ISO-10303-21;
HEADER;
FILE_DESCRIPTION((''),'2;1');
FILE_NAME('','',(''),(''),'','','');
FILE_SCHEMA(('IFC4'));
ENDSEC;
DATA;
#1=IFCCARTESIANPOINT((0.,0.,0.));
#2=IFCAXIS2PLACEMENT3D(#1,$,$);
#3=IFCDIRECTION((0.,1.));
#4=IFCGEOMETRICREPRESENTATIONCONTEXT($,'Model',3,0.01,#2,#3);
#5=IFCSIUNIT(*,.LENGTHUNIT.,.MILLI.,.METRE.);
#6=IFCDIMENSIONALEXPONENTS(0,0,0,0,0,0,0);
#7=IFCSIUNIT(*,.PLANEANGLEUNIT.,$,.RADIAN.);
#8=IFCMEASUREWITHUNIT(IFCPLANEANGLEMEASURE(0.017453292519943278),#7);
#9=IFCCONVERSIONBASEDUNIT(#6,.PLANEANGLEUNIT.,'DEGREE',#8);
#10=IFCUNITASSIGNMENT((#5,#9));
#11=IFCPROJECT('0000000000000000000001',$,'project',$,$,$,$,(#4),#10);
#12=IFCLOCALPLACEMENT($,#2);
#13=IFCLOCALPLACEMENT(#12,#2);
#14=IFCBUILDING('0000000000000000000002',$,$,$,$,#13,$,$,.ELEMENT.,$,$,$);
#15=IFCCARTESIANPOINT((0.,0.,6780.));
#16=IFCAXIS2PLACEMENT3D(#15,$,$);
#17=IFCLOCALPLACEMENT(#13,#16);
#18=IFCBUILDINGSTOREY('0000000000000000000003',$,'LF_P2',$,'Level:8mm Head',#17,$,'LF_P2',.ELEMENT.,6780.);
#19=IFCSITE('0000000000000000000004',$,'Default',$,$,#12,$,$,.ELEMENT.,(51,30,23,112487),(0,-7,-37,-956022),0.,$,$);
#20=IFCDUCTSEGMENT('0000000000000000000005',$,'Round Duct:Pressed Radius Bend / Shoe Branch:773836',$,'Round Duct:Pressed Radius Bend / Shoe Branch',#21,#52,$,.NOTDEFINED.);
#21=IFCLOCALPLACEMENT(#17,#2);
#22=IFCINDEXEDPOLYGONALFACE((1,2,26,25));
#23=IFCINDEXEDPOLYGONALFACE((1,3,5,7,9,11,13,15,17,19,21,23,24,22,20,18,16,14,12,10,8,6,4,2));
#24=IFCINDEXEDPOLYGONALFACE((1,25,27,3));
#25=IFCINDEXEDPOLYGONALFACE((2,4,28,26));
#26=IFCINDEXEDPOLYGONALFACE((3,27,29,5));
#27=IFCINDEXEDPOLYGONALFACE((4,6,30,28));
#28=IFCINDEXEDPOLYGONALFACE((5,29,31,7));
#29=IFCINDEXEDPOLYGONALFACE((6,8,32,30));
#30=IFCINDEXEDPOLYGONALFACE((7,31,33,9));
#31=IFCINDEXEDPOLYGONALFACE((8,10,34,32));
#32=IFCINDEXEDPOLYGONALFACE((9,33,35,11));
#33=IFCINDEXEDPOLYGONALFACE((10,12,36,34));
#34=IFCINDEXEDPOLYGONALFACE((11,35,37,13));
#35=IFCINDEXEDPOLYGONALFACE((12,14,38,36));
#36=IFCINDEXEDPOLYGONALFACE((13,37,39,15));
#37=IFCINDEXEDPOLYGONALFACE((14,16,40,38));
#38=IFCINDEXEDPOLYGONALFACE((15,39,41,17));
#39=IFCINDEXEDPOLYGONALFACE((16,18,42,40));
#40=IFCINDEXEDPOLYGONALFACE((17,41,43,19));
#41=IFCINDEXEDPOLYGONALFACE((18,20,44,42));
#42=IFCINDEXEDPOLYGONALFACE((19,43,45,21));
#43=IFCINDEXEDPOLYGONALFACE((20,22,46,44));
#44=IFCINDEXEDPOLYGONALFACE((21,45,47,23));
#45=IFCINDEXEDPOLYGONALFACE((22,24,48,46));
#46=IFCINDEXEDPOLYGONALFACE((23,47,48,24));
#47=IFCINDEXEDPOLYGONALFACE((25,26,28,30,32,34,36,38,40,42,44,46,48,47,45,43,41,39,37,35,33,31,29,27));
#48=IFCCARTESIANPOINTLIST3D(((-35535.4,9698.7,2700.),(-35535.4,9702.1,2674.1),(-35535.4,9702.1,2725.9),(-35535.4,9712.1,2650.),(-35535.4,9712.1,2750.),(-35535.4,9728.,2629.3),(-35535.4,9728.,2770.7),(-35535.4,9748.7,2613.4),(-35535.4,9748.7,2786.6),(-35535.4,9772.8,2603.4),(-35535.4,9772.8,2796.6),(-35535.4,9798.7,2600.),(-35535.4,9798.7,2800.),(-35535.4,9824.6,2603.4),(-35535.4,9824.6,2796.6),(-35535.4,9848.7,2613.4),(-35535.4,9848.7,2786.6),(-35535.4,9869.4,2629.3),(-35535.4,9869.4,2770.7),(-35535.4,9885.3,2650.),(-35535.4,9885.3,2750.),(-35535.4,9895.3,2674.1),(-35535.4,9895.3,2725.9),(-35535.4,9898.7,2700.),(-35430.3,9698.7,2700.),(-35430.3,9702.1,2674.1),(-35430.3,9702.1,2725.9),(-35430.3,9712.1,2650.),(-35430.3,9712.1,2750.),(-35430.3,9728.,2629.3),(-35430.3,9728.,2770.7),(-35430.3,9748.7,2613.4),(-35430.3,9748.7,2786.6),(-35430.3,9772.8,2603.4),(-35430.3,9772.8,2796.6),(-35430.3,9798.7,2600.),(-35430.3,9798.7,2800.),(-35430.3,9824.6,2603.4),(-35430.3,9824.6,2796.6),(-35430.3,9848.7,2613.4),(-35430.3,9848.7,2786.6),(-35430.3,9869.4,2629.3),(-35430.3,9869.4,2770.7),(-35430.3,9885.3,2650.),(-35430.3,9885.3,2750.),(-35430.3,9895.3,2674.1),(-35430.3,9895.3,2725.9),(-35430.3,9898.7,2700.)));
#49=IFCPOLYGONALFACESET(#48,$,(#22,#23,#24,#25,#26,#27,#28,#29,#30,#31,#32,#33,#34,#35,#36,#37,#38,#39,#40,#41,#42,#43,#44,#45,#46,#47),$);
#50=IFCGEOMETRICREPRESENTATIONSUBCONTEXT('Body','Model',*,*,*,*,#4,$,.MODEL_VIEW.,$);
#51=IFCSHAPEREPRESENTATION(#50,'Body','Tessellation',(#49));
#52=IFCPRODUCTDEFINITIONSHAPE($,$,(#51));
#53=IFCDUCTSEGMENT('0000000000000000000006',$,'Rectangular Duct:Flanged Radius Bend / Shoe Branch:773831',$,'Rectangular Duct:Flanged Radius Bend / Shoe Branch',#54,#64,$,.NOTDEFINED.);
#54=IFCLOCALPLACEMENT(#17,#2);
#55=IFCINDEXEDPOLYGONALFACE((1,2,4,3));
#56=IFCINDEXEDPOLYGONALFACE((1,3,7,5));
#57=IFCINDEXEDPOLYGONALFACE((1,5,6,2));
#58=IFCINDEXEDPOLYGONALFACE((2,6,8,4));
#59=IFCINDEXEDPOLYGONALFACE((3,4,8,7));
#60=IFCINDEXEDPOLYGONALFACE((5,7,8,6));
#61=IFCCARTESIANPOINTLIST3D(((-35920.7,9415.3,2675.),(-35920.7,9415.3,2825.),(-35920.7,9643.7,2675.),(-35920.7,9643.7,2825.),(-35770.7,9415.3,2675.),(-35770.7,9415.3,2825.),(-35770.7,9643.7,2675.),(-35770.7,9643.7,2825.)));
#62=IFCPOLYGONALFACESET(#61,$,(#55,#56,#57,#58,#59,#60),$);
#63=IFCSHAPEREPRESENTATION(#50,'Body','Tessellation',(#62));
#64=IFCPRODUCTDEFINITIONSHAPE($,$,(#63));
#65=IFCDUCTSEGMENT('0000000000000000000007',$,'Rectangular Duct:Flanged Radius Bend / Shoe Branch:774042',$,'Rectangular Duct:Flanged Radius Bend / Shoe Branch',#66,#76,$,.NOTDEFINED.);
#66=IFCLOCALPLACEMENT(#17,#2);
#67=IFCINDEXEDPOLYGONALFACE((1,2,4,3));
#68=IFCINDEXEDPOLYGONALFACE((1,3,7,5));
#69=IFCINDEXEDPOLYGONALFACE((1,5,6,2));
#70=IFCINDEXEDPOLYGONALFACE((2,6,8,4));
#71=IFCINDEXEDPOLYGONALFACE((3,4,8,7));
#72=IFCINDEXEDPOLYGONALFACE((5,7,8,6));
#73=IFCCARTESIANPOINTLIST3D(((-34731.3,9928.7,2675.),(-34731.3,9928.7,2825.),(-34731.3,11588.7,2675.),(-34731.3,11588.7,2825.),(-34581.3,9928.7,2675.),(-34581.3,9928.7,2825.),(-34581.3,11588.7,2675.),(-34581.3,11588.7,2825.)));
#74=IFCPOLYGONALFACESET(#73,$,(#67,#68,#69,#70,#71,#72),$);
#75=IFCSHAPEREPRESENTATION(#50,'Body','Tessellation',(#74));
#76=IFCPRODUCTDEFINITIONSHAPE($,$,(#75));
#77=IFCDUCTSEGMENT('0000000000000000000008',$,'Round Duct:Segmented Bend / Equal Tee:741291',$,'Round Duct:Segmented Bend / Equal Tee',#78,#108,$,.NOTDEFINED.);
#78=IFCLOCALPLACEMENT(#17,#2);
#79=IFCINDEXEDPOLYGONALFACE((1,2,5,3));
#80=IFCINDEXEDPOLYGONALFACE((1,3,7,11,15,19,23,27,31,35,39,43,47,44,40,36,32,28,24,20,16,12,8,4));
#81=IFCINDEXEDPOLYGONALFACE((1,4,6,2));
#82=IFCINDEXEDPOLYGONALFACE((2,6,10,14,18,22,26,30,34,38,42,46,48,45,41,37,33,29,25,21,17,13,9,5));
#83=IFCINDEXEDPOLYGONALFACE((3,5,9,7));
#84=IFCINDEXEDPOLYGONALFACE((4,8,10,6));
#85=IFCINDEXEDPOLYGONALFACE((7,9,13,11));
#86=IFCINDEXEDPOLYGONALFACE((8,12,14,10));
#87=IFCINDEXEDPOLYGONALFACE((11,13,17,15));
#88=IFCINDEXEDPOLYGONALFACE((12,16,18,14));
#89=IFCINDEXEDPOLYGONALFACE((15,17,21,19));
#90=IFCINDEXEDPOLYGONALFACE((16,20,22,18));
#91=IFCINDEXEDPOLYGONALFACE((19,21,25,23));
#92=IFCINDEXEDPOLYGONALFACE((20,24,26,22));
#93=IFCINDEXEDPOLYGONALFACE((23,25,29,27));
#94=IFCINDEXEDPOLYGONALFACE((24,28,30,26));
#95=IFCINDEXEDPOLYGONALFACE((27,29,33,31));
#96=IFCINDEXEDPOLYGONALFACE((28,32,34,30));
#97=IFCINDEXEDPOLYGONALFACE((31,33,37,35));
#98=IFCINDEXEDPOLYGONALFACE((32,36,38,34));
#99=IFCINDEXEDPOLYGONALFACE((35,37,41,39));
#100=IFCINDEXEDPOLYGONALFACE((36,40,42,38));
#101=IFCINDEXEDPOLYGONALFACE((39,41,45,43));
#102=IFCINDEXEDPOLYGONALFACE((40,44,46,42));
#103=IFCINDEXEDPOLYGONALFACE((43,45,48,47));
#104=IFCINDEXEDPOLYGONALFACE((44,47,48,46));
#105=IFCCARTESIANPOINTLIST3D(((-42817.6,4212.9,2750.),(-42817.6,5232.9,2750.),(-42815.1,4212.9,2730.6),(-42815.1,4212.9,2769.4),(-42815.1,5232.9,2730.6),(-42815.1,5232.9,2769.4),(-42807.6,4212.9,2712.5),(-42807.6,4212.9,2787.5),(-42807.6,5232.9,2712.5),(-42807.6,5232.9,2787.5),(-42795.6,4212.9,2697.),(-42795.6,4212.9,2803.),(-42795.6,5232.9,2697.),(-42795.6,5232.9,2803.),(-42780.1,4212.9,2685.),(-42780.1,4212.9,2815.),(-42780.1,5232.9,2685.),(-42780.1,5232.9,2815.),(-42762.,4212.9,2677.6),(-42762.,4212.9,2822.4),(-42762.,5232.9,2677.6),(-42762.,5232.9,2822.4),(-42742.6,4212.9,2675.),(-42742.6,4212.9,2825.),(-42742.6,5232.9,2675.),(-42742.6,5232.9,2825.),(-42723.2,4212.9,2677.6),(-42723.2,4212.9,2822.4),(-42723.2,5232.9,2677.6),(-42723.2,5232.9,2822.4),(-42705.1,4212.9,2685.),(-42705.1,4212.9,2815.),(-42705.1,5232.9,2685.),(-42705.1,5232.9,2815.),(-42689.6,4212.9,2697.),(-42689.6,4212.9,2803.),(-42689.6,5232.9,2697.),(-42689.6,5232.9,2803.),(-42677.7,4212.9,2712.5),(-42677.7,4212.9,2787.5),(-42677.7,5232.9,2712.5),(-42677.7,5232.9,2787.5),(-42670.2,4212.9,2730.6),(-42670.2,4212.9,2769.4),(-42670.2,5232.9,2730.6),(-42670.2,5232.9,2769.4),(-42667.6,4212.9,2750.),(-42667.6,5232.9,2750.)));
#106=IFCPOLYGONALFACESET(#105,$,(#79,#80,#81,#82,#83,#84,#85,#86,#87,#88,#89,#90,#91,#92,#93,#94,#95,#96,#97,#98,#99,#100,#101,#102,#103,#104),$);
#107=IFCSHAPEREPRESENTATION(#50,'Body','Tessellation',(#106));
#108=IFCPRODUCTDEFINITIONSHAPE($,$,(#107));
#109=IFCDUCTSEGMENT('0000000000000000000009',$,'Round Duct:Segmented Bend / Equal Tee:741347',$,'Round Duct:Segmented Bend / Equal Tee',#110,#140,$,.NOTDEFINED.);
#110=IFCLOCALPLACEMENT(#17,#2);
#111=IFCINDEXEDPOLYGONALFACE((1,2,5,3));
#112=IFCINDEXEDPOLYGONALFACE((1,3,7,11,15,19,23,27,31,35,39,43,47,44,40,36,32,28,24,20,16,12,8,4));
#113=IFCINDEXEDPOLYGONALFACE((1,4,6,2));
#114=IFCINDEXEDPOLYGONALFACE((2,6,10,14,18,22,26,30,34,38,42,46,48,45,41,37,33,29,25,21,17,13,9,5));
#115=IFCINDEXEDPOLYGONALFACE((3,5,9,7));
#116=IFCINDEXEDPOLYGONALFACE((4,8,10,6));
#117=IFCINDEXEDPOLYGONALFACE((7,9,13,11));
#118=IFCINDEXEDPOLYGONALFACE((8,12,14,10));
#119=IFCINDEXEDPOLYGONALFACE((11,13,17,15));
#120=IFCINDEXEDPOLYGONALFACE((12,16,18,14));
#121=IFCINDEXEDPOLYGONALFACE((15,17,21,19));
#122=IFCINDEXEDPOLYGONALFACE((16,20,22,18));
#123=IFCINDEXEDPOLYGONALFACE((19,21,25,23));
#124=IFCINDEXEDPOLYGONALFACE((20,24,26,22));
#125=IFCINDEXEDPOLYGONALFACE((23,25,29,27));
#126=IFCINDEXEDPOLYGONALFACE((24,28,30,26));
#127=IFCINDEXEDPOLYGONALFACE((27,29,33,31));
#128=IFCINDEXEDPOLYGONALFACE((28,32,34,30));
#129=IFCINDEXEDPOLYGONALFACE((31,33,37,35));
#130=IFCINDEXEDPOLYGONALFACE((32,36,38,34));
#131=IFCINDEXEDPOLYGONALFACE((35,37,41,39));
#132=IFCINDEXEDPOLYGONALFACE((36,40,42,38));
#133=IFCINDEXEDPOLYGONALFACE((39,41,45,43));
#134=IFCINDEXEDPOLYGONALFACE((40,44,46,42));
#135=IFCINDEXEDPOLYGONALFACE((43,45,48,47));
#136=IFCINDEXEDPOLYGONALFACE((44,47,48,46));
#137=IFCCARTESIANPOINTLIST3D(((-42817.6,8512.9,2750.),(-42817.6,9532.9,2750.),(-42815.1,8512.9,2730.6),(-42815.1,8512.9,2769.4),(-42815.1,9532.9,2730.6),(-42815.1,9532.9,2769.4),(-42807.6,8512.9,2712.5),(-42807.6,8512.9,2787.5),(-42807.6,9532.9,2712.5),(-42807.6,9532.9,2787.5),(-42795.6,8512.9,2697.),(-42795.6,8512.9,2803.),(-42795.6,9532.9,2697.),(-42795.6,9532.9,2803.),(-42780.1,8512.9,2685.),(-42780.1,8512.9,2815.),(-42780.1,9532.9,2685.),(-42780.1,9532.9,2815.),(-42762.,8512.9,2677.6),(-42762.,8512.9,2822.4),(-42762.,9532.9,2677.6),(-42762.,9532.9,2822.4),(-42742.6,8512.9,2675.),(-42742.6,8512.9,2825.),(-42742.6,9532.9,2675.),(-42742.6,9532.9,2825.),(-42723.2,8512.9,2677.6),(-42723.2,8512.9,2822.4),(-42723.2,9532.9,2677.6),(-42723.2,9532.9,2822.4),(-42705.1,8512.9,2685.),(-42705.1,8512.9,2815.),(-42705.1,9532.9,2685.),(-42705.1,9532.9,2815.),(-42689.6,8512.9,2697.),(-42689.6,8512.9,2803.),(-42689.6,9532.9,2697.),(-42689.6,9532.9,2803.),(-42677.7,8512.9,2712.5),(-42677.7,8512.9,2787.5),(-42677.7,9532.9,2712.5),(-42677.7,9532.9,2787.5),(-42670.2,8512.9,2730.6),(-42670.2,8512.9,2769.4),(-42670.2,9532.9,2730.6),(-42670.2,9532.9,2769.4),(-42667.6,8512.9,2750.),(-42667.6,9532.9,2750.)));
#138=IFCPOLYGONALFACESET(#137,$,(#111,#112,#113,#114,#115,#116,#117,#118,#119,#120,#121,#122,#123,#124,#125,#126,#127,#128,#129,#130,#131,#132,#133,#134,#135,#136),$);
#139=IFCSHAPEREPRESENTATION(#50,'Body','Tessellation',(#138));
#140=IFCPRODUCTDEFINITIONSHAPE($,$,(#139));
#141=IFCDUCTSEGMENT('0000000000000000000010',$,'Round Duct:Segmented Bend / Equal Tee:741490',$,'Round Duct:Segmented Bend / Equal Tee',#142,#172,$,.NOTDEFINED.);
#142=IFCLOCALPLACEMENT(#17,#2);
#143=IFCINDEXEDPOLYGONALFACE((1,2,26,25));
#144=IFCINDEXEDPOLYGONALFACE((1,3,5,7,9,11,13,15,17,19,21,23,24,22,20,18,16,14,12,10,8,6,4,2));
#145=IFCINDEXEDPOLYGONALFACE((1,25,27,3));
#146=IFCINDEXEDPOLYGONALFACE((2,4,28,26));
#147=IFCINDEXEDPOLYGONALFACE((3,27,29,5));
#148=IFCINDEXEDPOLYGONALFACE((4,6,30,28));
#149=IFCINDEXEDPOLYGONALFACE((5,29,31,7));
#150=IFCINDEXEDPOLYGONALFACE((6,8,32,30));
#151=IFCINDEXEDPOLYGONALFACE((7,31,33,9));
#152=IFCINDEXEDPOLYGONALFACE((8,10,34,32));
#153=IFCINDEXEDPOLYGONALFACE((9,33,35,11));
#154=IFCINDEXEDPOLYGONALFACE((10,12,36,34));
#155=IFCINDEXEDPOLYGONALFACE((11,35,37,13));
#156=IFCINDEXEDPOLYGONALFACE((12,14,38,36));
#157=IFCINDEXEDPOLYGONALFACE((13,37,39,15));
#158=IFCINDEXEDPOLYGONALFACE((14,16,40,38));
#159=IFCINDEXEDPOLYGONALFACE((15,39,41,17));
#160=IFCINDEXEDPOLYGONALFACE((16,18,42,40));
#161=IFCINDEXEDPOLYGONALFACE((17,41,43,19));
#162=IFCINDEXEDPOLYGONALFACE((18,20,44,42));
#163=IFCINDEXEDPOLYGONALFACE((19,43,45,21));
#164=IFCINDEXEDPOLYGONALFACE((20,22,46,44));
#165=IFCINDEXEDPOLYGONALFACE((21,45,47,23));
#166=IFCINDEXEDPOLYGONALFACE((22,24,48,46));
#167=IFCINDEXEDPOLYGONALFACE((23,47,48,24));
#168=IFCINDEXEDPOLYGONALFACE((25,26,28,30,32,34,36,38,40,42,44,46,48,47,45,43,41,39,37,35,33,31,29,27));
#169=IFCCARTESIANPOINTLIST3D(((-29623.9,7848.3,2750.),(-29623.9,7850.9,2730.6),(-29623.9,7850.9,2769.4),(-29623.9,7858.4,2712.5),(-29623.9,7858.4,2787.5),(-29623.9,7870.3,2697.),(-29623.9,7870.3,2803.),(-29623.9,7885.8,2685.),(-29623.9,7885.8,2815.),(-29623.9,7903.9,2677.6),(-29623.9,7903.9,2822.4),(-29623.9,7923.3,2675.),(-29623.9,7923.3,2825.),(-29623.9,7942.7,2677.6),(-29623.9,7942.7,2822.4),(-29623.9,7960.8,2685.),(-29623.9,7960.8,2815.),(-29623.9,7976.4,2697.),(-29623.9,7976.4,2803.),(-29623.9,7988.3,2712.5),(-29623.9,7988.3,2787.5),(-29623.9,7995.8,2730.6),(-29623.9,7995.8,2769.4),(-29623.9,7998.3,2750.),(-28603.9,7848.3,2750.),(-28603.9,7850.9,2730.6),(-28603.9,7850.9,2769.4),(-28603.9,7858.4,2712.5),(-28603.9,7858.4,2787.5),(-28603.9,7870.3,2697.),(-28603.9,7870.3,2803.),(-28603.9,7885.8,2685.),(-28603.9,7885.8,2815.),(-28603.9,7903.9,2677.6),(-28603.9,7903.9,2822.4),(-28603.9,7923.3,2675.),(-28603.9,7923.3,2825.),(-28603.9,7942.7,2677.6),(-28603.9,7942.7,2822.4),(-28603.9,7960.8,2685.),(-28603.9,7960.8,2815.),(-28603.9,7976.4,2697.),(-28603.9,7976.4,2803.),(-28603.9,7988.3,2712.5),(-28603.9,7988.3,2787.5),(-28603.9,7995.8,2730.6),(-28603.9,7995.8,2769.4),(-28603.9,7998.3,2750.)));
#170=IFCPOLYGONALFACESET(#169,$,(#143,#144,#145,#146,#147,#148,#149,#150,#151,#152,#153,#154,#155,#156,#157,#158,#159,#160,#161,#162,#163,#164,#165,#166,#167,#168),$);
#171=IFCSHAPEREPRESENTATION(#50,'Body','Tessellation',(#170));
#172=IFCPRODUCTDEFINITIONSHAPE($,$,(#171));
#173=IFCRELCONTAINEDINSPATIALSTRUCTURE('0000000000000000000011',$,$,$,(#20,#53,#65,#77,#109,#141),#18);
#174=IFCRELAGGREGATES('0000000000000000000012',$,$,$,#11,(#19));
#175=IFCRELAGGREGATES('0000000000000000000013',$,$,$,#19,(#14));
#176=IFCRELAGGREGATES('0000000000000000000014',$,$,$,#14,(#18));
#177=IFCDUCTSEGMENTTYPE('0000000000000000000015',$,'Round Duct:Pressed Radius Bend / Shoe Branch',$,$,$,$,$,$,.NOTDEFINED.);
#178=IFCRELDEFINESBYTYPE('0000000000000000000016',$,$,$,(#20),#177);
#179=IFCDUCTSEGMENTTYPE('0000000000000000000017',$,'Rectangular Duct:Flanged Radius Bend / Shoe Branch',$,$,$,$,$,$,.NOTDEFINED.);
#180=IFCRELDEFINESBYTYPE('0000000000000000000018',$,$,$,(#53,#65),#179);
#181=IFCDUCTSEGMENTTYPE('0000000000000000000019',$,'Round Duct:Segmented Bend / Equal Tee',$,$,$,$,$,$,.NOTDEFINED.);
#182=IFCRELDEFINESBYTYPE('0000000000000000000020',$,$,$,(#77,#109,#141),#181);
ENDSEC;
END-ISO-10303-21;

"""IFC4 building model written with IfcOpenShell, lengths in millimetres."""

from ifc_helpers import new_model, entity, si_unit, converted_unit, direction, frame, origin, place, context, subcontext, project, spatial, arc, indexed_curve, outline, extrude, type_object, element, save


model = new_model("IFC4")

# Units and contexts
model_context = context("Model", 3, precision=0.01, world=origin(), true_north=direction((0.0, 1.0)))
body_context = subcontext(model_context, "Body", "Model", "MODEL_VIEW")
ifc_project = project(units=[si_unit("LENGTHUNIT", "METRE", prefix="MILLI"), converted_unit("PLANEANGLEUNIT", "DEGREE", entity("IfcPlaneAngleMeasure", 0.017453292519943278), si_unit("PLANEANGLEUNIT", "RADIAN"), dimensions=[0, 0, 0, 0, 0, 0, 0])], contexts=[model_context])

# Site, building, storey
site_placement = place(None, origin())
site = spatial("IfcSite", under=ifc_project, at=site_placement, Name="Default", CompositionType="ELEMENT", RefLatitude=(51, 30, 23, 112487), RefLongitude=(0, -7, -37, -956022), RefElevation=0.0)
building_placement = place(site_placement, origin())
building = spatial("IfcBuilding", under=site, at=building_placement, CompositionType="ELEMENT")
storey_placement = place(building_placement, frame((0.0, 0.0, 6780.0)))
storey = spatial("IfcBuildingStorey", under=building, at=storey_placement, Name="LF_P2", ObjectType="Level:8mm Head", LongName="LF_P2", CompositionType="ELEMENT", Elevation=6780.0)

# Duct segments
duct_segment_type_1 = type_object("IfcDuctSegmentType", Name="Round Duct:Pressed Radius Bend / Shoe Branch", PredefinedType="NOTDEFINED")
duct_segment_1_placement = place(storey_placement, origin())
element("IfcDuctSegment", 1, at=duct_segment_1_placement, inside=storey, type_object=duct_segment_type_1, Name="Round Duct:Pressed Radius Bend / Shoe Branch:773836", ObjectType="Round Duct:Pressed Radius Bend / Shoe Branch", PredefinedType="NOTDEFINED", context=body_context, shape_type="SweptSolid", body=[
    extrude(outline(indexed_curve([(100.0, 0.0), (70.7, 70.7), (0.0, 100.0), (-70.7, 70.7), (-100.0, 0.0), (-70.7, -70.7), (0.0, -100.0), (70.7, -70.7)], segments=[arc(1, 2, 3), arc(3, 4, 5), arc(5, 6, 7), arc(7, 8, 1)], self_intersect=False)), frame((-35535.4, 9798.7, 2700.0), z_axis=(1.0, 0.0, 0.0), x_axis=(0.0, 1.0, 0.0)), (0.0, 0.0, 1.0), 105.0),
])
duct_segment_type_2 = type_object("IfcDuctSegmentType", Name="Rectangular Duct:Flanged Radius Bend / Shoe Branch", PredefinedType="NOTDEFINED")
duct_segment_2_placement = place(storey_placement, origin())
element("IfcDuctSegment", 2, at=duct_segment_2_placement, inside=storey, type_object=duct_segment_type_2, Name="Rectangular Duct:Flanged Radius Bend / Shoe Branch:773831", ObjectType="Rectangular Duct:Flanged Radius Bend / Shoe Branch", PredefinedType="NOTDEFINED", context=body_context, shape_type="SweptSolid", body=[
    extrude(outline(indexed_curve([(-114.2, -75.0), (114.2, -75.0), (114.2, 75.0), (-114.2, 75.0), (-114.2, -75.0)], self_intersect=False)), frame((-35845.7, 9529.5, 2675.0), z_axis=(0.0, 0.0, 1.0), x_axis=(0.0, -1.0, 0.0)), (0.0, 0.0, 1.0), 150.0),
])
duct_segment_3_placement = place(storey_placement, origin())
element("IfcDuctSegment", 3, at=duct_segment_3_placement, inside=storey, type_object=duct_segment_type_2, Name="Rectangular Duct:Flanged Radius Bend / Shoe Branch:774042", ObjectType="Rectangular Duct:Flanged Radius Bend / Shoe Branch", PredefinedType="NOTDEFINED", context=body_context, shape_type="SweptSolid", body=[
    extrude(outline(indexed_curve([(-830.0, -75.0), (830.0, -75.0), (830.0, 75.0), (-830.0, 75.0), (-830.0, -75.0)], self_intersect=False)), frame((-34656.3, 10758.7, 2675.0), z_axis=(0.0, 0.0, 1.0), x_axis=(0.0, -1.0, 0.0)), (0.0, 0.0, 1.0), 150.0),
])
duct_segment_type_3 = type_object("IfcDuctSegmentType", Name="Round Duct:Segmented Bend / Equal Tee", PredefinedType="NOTDEFINED")
duct_segment_4_placement = place(storey_placement, origin())
element("IfcDuctSegment", 4, at=duct_segment_4_placement, inside=storey, type_object=duct_segment_type_3, Name="Round Duct:Segmented Bend / Equal Tee:741291", ObjectType="Round Duct:Segmented Bend / Equal Tee", PredefinedType="NOTDEFINED", context=body_context, shape_type="SweptSolid", body=[
    extrude(outline(indexed_curve([(75.0, 0.0), (53.0, 53.0), (0.0, 75.0), (-53.0, 53.0), (-75.0, 0.0), (-53.0, -53.0), (0.0, -75.0), (53.0, -53.0)], segments=[arc(1, 2, 3), arc(3, 4, 5), arc(5, 6, 7), arc(7, 8, 1)], self_intersect=False)), frame((-42742.6, 4212.9, 2750.0), z_axis=(0.0, 1.0, 0.0), x_axis=(1.0, 0.0, 0.0)), (0.0, 0.0, 1.0), 1020.0),
])
duct_segment_5_placement = place(storey_placement, origin())
element("IfcDuctSegment", 5, at=duct_segment_5_placement, inside=storey, type_object=duct_segment_type_3, Name="Round Duct:Segmented Bend / Equal Tee:741347", ObjectType="Round Duct:Segmented Bend / Equal Tee", PredefinedType="NOTDEFINED", context=body_context, shape_type="SweptSolid", body=[
    extrude(outline(indexed_curve([(75.0, 0.0), (53.0, 53.0), (0.0, 75.0), (-53.0, 53.0), (-75.0, 0.0), (-53.0, -53.0), (0.0, -75.0), (53.0, -53.0)], segments=[arc(1, 2, 3), arc(3, 4, 5), arc(5, 6, 7), arc(7, 8, 1)], self_intersect=False)), frame((-42742.6, 8512.9, 2750.0), z_axis=(0.0, 1.0, 0.0), x_axis=(1.0, 0.0, 0.0)), (0.0, 0.0, 1.0), 1020.0),
])
duct_segment_6_placement = place(storey_placement, origin())
element("IfcDuctSegment", 6, at=duct_segment_6_placement, inside=storey, type_object=duct_segment_type_3, Name="Round Duct:Segmented Bend / Equal Tee:741490", ObjectType="Round Duct:Segmented Bend / Equal Tee", PredefinedType="NOTDEFINED", context=body_context, shape_type="SweptSolid", body=[
    extrude(outline(indexed_curve([(75.0, 0.0), (53.0, 53.0), (0.0, 75.0), (-53.0, 53.0), (-75.0, 0.0), (-53.0, -53.0), (0.0, -75.0), (53.0, -53.0)], segments=[arc(1, 2, 3), arc(3, 4, 5), arc(5, 6, 7), arc(7, 8, 1)], self_intersect=False)), frame((-29623.9, 7923.3, 2750.0), z_axis=(1.0, 0.0, 0.0), x_axis=(0.0, 1.0, 0.0)), (0.0, 0.0, 1.0), 1020.0),
])

save(model, "model.ifc")
